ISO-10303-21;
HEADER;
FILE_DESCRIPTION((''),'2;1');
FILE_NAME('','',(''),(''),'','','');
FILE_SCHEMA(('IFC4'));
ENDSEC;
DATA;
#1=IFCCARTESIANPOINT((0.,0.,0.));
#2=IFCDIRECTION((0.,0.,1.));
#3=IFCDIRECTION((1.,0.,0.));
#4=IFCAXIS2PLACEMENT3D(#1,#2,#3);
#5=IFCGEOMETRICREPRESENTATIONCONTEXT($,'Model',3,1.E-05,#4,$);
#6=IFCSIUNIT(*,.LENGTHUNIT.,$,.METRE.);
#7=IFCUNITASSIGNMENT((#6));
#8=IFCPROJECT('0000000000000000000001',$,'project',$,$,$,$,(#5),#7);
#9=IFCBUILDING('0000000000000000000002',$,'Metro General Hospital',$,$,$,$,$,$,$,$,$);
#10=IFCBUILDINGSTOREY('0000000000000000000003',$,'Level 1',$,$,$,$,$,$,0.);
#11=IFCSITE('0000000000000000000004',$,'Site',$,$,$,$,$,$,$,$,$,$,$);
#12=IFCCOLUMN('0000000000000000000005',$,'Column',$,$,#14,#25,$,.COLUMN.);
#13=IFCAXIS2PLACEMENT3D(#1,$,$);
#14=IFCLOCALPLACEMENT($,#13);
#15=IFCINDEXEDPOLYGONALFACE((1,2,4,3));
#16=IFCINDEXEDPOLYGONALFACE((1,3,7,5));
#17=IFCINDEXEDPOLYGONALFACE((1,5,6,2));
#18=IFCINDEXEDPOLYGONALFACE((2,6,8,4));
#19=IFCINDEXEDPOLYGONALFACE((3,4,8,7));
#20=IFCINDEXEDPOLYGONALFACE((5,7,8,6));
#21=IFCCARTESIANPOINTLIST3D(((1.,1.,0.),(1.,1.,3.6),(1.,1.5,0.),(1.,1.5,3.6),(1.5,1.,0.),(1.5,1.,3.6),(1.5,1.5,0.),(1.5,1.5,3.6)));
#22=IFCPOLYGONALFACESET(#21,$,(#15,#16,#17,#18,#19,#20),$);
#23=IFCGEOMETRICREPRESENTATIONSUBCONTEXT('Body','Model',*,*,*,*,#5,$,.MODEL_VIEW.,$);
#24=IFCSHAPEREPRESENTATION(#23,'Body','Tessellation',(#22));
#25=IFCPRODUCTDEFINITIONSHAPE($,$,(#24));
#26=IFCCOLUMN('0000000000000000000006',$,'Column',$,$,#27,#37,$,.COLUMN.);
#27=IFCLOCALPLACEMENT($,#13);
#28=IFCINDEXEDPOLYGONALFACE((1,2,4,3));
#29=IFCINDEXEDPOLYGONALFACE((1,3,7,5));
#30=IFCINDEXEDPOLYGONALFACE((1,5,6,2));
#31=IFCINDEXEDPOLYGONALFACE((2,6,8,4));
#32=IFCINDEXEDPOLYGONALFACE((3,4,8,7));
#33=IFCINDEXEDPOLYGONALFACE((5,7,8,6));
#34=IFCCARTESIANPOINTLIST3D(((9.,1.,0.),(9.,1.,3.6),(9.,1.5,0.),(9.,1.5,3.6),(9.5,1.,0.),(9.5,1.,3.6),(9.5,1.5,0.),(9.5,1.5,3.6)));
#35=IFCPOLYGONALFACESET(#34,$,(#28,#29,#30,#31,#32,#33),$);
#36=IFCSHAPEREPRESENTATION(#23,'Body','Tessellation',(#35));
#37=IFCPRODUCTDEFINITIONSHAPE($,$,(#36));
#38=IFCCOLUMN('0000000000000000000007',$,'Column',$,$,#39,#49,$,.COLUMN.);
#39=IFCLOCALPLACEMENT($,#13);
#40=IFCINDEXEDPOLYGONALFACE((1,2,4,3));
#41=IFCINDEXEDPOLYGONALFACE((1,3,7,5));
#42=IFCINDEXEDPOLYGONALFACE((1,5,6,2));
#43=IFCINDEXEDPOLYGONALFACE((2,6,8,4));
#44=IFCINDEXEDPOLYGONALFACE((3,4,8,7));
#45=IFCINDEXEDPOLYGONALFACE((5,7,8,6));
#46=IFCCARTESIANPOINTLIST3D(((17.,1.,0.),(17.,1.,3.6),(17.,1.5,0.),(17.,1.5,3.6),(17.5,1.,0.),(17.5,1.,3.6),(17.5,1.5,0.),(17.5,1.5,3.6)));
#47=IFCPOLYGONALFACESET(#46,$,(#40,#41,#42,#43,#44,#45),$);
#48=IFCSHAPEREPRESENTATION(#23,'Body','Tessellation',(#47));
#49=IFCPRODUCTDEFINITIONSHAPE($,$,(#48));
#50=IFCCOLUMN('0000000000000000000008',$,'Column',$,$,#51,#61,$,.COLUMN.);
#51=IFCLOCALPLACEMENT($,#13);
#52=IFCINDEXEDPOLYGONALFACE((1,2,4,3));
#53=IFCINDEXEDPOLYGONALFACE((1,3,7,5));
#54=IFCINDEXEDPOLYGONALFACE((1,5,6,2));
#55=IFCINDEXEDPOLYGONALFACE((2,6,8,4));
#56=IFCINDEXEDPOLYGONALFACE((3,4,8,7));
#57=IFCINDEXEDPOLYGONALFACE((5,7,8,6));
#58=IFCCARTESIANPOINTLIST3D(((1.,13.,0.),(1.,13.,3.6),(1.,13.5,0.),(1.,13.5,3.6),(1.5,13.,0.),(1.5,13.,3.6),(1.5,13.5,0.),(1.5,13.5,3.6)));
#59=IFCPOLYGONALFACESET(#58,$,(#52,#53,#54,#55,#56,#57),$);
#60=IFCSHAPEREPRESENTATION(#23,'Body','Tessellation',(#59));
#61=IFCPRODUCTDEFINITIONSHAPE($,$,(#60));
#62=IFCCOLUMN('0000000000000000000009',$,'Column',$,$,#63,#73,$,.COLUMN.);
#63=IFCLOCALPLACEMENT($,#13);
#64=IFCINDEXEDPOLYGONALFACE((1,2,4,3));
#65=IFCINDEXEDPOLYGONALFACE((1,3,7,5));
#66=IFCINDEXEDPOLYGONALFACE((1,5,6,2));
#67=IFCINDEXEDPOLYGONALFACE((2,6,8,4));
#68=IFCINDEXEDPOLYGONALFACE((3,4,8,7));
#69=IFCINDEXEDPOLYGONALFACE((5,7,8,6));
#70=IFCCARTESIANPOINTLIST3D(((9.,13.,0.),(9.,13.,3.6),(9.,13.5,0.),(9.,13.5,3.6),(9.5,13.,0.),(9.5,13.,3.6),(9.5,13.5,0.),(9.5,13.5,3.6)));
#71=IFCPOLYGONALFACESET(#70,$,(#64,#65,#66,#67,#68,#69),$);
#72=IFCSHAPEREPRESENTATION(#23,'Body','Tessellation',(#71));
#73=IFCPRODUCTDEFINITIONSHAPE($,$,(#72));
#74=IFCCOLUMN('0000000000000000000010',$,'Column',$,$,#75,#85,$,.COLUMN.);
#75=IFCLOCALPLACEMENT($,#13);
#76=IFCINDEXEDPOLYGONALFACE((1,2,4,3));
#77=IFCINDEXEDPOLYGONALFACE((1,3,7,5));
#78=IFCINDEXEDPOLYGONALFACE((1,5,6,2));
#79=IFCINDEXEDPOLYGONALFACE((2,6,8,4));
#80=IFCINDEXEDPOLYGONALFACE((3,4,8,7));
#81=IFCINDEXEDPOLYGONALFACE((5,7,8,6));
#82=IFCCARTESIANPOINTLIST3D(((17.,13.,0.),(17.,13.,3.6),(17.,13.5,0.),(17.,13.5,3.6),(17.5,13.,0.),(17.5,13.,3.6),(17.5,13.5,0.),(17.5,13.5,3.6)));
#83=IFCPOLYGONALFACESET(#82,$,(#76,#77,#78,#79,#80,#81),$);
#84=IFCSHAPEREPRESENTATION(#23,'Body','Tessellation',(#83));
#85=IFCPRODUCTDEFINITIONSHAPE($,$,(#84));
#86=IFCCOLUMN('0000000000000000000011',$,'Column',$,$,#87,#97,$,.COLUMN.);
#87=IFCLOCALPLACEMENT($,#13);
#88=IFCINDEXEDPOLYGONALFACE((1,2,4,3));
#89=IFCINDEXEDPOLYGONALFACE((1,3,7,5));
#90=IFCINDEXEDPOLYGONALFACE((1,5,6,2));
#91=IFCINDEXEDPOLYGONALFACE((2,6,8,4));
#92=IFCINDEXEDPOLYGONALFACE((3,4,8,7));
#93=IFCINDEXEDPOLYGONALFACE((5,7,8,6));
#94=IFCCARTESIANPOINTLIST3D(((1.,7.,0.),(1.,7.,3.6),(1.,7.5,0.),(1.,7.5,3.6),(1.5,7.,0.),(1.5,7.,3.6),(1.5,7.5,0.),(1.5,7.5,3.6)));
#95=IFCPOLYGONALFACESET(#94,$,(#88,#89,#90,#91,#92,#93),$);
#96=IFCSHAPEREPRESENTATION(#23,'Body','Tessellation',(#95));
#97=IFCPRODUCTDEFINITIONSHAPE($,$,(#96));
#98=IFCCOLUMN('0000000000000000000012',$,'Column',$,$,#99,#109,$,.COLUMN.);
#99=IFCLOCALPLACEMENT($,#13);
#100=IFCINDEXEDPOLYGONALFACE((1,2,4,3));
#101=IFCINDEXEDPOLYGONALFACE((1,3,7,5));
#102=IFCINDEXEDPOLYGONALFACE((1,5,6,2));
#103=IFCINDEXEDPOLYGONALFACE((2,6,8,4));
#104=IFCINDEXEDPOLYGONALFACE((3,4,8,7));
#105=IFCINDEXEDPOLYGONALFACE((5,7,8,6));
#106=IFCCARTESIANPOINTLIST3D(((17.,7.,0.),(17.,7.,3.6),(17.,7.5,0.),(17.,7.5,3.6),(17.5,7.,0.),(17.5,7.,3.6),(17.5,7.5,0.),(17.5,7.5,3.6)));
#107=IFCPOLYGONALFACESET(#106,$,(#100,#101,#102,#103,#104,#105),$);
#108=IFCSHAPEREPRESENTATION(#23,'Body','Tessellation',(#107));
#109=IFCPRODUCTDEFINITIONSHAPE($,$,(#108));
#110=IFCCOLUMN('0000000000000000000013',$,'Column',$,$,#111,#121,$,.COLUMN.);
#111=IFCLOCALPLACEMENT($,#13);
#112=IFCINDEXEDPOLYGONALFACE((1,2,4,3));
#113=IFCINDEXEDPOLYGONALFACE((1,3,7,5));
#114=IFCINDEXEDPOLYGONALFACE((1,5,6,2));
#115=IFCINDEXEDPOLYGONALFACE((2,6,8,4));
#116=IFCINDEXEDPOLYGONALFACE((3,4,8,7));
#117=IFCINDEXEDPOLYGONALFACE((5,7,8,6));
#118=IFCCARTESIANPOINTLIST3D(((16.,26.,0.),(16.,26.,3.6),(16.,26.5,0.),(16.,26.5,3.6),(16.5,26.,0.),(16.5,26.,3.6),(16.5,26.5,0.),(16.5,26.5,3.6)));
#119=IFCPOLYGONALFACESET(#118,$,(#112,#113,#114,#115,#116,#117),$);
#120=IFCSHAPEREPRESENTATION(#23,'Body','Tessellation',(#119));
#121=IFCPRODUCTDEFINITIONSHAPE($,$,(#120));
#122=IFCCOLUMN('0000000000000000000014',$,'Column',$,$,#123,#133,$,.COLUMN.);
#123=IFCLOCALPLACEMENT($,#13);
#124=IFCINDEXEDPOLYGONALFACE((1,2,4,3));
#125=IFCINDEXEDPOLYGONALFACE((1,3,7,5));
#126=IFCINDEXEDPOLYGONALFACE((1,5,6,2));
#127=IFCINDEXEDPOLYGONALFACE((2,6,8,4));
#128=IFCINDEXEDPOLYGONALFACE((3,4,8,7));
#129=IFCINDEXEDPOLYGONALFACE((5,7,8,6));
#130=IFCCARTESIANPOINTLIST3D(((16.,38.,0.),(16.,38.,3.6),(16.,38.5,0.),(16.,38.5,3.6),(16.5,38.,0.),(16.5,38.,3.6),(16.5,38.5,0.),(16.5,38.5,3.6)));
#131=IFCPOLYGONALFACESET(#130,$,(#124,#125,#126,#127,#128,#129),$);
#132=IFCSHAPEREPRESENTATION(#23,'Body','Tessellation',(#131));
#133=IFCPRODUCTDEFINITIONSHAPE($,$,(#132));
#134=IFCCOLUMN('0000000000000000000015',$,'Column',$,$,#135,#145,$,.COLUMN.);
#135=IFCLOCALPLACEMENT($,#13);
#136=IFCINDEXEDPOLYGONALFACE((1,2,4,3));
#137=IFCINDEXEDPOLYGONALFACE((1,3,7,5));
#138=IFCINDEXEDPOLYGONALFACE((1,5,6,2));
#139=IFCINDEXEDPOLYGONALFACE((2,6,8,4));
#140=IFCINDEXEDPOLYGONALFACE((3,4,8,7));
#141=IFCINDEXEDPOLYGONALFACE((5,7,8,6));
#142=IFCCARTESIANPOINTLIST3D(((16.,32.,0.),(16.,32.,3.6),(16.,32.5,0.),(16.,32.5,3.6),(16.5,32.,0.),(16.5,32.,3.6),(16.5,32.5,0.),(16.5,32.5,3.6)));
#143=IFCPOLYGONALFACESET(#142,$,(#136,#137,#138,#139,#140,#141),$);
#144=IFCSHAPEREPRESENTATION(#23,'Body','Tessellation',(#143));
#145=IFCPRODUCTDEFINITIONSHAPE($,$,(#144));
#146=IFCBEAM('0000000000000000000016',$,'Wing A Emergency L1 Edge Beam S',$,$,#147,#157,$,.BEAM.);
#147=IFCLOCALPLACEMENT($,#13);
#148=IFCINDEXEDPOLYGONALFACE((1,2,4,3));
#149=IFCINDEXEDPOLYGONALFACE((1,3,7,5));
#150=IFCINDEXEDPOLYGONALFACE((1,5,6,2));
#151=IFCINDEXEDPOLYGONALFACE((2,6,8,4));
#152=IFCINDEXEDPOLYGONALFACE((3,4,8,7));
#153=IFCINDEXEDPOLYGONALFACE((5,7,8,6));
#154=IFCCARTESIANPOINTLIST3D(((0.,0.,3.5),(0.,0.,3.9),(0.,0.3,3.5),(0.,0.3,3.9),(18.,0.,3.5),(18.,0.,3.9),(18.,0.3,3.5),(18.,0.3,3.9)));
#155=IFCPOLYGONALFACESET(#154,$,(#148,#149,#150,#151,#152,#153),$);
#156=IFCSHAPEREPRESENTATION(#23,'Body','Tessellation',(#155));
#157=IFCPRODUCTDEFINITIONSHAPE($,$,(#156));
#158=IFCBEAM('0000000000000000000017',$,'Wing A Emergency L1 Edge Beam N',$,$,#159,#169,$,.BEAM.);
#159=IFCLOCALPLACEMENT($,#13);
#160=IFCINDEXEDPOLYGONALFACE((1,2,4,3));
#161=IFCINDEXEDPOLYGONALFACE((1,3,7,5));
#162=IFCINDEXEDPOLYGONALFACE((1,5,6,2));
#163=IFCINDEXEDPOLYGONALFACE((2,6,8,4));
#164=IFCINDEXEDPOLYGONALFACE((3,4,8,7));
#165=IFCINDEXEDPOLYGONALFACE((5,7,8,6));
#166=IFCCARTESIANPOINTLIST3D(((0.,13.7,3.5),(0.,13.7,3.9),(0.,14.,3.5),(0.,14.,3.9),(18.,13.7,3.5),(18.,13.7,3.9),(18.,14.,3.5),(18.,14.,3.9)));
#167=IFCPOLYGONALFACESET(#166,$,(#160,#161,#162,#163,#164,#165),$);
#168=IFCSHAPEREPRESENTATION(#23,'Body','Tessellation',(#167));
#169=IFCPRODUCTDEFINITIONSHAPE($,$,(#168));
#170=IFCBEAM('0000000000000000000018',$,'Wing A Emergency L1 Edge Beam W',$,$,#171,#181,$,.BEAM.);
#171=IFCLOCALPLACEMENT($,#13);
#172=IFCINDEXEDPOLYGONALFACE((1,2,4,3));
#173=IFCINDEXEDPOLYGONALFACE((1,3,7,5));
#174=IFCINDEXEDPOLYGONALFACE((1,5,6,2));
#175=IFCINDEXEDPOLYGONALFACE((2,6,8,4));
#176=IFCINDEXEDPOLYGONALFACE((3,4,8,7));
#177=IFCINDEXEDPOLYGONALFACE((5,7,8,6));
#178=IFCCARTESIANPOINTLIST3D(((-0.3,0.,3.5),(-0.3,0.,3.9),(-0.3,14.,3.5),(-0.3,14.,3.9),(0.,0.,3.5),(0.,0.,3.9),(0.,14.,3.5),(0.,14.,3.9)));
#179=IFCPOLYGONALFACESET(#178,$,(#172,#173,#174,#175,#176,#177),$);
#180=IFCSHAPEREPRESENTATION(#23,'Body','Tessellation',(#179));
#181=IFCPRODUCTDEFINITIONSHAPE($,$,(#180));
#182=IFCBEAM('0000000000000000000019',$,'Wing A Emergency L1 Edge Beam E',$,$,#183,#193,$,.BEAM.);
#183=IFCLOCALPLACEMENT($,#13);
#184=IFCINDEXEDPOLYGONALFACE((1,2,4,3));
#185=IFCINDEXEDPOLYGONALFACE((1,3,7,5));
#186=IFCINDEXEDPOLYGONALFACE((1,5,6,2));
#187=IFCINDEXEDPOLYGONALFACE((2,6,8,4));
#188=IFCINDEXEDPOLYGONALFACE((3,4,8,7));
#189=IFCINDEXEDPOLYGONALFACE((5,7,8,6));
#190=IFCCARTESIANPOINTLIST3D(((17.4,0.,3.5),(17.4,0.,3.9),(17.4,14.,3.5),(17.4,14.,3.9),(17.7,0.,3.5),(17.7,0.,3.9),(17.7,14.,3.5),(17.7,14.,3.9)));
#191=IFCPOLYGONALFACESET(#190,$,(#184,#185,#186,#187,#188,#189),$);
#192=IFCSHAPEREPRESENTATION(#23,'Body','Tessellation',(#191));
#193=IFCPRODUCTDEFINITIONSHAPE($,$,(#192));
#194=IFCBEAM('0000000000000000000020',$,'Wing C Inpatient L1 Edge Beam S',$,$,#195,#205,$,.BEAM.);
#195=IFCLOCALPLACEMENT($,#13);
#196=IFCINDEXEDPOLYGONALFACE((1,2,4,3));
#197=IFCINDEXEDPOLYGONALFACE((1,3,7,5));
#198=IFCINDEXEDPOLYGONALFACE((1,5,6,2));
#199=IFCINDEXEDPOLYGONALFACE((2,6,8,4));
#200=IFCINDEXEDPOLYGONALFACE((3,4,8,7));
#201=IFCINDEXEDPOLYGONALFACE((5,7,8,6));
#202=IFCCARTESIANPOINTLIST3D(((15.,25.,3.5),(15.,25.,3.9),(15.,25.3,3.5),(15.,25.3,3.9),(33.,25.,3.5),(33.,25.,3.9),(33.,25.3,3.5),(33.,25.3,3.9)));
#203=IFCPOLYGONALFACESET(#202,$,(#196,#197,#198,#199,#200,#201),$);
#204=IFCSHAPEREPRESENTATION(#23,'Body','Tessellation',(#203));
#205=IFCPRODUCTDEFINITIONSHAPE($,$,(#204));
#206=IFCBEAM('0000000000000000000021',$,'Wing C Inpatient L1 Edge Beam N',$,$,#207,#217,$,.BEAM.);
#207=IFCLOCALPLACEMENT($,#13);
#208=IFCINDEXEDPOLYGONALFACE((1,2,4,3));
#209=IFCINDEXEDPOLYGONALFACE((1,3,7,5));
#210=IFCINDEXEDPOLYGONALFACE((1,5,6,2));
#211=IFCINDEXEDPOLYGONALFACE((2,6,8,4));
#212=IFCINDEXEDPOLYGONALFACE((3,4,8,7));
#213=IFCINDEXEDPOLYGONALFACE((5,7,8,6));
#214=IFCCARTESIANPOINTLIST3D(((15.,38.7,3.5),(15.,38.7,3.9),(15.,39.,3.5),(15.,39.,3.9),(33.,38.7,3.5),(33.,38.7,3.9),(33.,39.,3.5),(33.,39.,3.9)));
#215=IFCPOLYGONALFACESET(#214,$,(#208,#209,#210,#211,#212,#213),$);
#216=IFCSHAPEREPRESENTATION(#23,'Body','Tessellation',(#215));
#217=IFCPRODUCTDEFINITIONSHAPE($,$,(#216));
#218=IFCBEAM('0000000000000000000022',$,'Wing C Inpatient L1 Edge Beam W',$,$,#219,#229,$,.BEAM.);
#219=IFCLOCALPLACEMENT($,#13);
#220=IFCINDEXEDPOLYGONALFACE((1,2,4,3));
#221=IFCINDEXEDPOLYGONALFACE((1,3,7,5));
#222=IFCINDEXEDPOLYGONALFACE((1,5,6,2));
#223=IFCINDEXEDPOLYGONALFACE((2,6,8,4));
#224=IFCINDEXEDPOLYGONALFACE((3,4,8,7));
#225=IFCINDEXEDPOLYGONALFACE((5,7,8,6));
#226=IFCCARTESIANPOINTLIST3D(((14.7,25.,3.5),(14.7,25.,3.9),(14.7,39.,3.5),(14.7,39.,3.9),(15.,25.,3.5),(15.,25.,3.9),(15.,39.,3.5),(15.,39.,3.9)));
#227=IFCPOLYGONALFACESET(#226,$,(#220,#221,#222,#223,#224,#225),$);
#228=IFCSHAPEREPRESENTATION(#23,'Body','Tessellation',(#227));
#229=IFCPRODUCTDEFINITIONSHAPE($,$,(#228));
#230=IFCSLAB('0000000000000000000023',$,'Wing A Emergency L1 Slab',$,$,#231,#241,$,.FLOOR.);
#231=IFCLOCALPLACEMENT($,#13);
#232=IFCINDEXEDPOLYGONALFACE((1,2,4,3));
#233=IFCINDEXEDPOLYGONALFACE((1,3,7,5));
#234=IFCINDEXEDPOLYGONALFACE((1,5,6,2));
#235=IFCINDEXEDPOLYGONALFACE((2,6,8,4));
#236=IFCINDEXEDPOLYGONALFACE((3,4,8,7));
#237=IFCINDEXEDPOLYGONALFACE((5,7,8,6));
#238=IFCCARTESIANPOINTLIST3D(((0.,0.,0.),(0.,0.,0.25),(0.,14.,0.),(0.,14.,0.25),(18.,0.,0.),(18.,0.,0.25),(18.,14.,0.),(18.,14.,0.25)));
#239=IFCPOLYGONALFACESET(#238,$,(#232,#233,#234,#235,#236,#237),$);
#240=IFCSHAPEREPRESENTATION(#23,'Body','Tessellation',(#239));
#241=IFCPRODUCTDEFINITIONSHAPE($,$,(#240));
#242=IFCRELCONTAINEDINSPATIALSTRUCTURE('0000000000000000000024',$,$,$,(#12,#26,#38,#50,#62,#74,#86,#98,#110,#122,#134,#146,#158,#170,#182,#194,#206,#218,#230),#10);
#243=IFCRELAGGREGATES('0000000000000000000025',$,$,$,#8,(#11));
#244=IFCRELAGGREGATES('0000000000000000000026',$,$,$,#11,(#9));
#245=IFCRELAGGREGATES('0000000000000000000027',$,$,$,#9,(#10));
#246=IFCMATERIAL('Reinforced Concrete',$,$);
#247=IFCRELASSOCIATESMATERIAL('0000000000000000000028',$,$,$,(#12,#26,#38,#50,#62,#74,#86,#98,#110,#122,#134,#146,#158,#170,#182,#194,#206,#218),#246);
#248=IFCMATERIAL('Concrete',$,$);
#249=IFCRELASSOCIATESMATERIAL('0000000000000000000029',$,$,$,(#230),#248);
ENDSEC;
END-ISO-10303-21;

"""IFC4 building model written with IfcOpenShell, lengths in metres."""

from ifc_helpers import new_model, si_unit, frame, origin_with_axes, place, context, subcontext, project, spatial, line, indexed_curve, outline, extrude, material, element, save


model = new_model("IFC4")

# Units and contexts
model_context = context("Model", 3, precision=1e-05, world=origin_with_axes())
body_context = subcontext(model_context, "Body", "Model", "MODEL_VIEW")
ifc_project = project(units=[si_unit("LENGTHUNIT", "METRE")], contexts=[model_context])

# Site, building, storey
site = spatial("IfcSite", under=ifc_project, Name="Site")
building = spatial("IfcBuilding", under=site, Name="Metro General Hospital")
storey = spatial("IfcBuildingStorey", under=building, Name="Level 1", Elevation=0.0)

# Columns
ifc_material_1 = material(Name="Reinforced Concrete")
for number, where, z_axis, x_axis, name in (
    (1, (1.0, 1.0, 0.0), (0.0, 0.0, 1.0), (1.0, 0.0, 0.0), "Column"),
    (2, (9.0, 1.0, 0.0), (0.0, 0.0, 1.0), (1.0, 0.0, 0.0), "Column"),
    (3, (17.0, 1.0, 0.0), (0.0, 0.0, 1.0), (1.0, 0.0, 0.0), "Column"),
    (4, (1.0, 13.0, 0.0), (0.0, 0.0, 1.0), (1.0, 0.0, 0.0), "Column"),
    (5, (9.0, 13.0, 0.0), (0.0, 0.0, 1.0), (1.0, 0.0, 0.0), "Column"),
    (6, (17.0, 13.0, 0.0), (0.0, 0.0, 1.0), (1.0, 0.0, 0.0), "Column"),
    (7, (1.0, 7.0, 0.0), (0.0, 0.0, 1.0), (1.0, 0.0, 0.0), "Column"),
    (8, (17.0, 7.0, 0.0), (0.0, 0.0, 1.0), (1.0, 0.0, 0.0), "Column"),
    (9, (16.0, 26.0, 0.0), (0.0, 0.0, 1.0), (1.0, 0.0, 0.0), "Column"),
    (10, (16.0, 38.0, 0.0), (0.0, 0.0, 1.0), (1.0, 0.0, 0.0), "Column"),
    (11, (16.0, 32.0, 0.0), (0.0, 0.0, 1.0), (1.0, 0.0, 0.0), "Column"),
):
    element("IfcColumn", number, at=place(None, frame(where, z_axis=z_axis, x_axis=x_axis)), inside=storey, material=ifc_material_1, Name=name, PredefinedType="COLUMN", context=body_context, shape_type="SweptSolid", body=[
        extrude(outline(indexed_curve([(0.0, 0.0), (0.5, 0.0), (0.5, 0.5), (0.0, 0.5)], segments=[line(1, 2, 3, 4, 1)])), origin_with_axes(), (0.0, 0.0, 1.0), 3.6),
    ])

# Beams
for number, where, z_axis, x_axis, name in (
    (12, (0.0, 0.0, 3.5), (0.0, 0.0, 1.0), (1.0, 0.0, 0.0), "Wing A Emergency L1 Edge Beam S"),
    (13, (0.0, 13.7, 3.5), (0.0, 0.0, 1.0), (1.0, 0.0, 0.0), "Wing A Emergency L1 Edge Beam N"),
):
    element("IfcBeam", number, at=place(None, frame(where, z_axis=z_axis, x_axis=x_axis)), inside=storey, material=ifc_material_1, Name=name, PredefinedType="BEAM", context=body_context, shape_type="SweptSolid", body=[
        extrude(outline(indexed_curve([(0.0, 0.0), (18.0, 0.0), (18.0, 0.3), (0.0, 0.3)], segments=[line(1, 2, 3, 4, 1)])), origin_with_axes(), (0.0, 0.0, 1.0), 0.4),
    ])
for number, where, z_axis, x_axis, name in (
    (14, (0.0, 0.0, 3.5), (0.0, 0.0, 1.0), (0.0, 1.0, 0.0), "Wing A Emergency L1 Edge Beam W"),
    (15, (17.7, 0.0, 3.5), (0.0, 0.0, 1.0), (0.0, 1.0, 0.0), "Wing A Emergency L1 Edge Beam E"),
):
    element("IfcBeam", number, at=place(None, frame(where, z_axis=z_axis, x_axis=x_axis)), inside=storey, material=ifc_material_1, Name=name, PredefinedType="BEAM", context=body_context, shape_type="SweptSolid", body=[
        extrude(outline(indexed_curve([(0.0, 0.0), (14.0, 0.0), (14.0, 0.3), (0.0, 0.3)], segments=[line(1, 2, 3, 4, 1)])), origin_with_axes(), (0.0, 0.0, 1.0), 0.4),
    ])
for number, where, z_axis, x_axis, name in (
    (16, (15.0, 25.0, 3.5), (0.0, 0.0, 1.0), (1.0, 0.0, 0.0), "Wing C Inpatient L1 Edge Beam S"),
    (17, (15.0, 38.7, 3.5), (0.0, 0.0, 1.0), (1.0, 0.0, 0.0), "Wing C Inpatient L1 Edge Beam N"),
):
    element("IfcBeam", number, at=place(None, frame(where, z_axis=z_axis, x_axis=x_axis)), inside=storey, material=ifc_material_1, Name=name, PredefinedType="BEAM", context=body_context, shape_type="SweptSolid", body=[
        extrude(outline(indexed_curve([(0.0, 0.0), (18.0, 0.0), (18.0, 0.3), (0.0, 0.3)], segments=[line(1, 2, 3, 4, 1)])), origin_with_axes(), (0.0, 0.0, 1.0), 0.4),
    ])
beam_placement = place(None, frame((15.0, 25.0, 3.5), z_axis=(0.0, 0.0, 1.0), x_axis=(0.0, 1.0, 0.0)))
element("IfcBeam", 18, at=beam_placement, inside=storey, material=ifc_material_1, Name="Wing C Inpatient L1 Edge Beam W", PredefinedType="BEAM", context=body_context, shape_type="SweptSolid", body=[
    extrude(outline(indexed_curve([(0.0, 0.0), (14.0, 0.0), (14.0, 0.3), (0.0, 0.3)], segments=[line(1, 2, 3, 4, 1)])), origin_with_axes(), (0.0, 0.0, 1.0), 0.4),
])

# Slab
ifc_material_2 = material(Name="Concrete")
for number, where, z_axis, x_axis, name in (
    (19, (0.0, 0.0, 0.0), (0.0, 0.0, 1.0), (1.0, 0.0, 0.0), "Wing A Emergency L1 Slab"),
):
    element("IfcSlab", number, at=place(None, frame(where, z_axis=z_axis, x_axis=x_axis)), inside=storey, material=ifc_material_2, Name=name, PredefinedType="FLOOR", context=body_context, shape_type="SweptSolid", body=[
        extrude(outline(indexed_curve([(0.0, 0.0), (18.0, 0.0), (18.0, 14.0), (0.0, 14.0)], segments=[line(1, 2, 3, 4, 1)])), origin_with_axes(), (0.0, 0.0, 1.0), 0.25),
    ])

save(model, "model.ifc")
